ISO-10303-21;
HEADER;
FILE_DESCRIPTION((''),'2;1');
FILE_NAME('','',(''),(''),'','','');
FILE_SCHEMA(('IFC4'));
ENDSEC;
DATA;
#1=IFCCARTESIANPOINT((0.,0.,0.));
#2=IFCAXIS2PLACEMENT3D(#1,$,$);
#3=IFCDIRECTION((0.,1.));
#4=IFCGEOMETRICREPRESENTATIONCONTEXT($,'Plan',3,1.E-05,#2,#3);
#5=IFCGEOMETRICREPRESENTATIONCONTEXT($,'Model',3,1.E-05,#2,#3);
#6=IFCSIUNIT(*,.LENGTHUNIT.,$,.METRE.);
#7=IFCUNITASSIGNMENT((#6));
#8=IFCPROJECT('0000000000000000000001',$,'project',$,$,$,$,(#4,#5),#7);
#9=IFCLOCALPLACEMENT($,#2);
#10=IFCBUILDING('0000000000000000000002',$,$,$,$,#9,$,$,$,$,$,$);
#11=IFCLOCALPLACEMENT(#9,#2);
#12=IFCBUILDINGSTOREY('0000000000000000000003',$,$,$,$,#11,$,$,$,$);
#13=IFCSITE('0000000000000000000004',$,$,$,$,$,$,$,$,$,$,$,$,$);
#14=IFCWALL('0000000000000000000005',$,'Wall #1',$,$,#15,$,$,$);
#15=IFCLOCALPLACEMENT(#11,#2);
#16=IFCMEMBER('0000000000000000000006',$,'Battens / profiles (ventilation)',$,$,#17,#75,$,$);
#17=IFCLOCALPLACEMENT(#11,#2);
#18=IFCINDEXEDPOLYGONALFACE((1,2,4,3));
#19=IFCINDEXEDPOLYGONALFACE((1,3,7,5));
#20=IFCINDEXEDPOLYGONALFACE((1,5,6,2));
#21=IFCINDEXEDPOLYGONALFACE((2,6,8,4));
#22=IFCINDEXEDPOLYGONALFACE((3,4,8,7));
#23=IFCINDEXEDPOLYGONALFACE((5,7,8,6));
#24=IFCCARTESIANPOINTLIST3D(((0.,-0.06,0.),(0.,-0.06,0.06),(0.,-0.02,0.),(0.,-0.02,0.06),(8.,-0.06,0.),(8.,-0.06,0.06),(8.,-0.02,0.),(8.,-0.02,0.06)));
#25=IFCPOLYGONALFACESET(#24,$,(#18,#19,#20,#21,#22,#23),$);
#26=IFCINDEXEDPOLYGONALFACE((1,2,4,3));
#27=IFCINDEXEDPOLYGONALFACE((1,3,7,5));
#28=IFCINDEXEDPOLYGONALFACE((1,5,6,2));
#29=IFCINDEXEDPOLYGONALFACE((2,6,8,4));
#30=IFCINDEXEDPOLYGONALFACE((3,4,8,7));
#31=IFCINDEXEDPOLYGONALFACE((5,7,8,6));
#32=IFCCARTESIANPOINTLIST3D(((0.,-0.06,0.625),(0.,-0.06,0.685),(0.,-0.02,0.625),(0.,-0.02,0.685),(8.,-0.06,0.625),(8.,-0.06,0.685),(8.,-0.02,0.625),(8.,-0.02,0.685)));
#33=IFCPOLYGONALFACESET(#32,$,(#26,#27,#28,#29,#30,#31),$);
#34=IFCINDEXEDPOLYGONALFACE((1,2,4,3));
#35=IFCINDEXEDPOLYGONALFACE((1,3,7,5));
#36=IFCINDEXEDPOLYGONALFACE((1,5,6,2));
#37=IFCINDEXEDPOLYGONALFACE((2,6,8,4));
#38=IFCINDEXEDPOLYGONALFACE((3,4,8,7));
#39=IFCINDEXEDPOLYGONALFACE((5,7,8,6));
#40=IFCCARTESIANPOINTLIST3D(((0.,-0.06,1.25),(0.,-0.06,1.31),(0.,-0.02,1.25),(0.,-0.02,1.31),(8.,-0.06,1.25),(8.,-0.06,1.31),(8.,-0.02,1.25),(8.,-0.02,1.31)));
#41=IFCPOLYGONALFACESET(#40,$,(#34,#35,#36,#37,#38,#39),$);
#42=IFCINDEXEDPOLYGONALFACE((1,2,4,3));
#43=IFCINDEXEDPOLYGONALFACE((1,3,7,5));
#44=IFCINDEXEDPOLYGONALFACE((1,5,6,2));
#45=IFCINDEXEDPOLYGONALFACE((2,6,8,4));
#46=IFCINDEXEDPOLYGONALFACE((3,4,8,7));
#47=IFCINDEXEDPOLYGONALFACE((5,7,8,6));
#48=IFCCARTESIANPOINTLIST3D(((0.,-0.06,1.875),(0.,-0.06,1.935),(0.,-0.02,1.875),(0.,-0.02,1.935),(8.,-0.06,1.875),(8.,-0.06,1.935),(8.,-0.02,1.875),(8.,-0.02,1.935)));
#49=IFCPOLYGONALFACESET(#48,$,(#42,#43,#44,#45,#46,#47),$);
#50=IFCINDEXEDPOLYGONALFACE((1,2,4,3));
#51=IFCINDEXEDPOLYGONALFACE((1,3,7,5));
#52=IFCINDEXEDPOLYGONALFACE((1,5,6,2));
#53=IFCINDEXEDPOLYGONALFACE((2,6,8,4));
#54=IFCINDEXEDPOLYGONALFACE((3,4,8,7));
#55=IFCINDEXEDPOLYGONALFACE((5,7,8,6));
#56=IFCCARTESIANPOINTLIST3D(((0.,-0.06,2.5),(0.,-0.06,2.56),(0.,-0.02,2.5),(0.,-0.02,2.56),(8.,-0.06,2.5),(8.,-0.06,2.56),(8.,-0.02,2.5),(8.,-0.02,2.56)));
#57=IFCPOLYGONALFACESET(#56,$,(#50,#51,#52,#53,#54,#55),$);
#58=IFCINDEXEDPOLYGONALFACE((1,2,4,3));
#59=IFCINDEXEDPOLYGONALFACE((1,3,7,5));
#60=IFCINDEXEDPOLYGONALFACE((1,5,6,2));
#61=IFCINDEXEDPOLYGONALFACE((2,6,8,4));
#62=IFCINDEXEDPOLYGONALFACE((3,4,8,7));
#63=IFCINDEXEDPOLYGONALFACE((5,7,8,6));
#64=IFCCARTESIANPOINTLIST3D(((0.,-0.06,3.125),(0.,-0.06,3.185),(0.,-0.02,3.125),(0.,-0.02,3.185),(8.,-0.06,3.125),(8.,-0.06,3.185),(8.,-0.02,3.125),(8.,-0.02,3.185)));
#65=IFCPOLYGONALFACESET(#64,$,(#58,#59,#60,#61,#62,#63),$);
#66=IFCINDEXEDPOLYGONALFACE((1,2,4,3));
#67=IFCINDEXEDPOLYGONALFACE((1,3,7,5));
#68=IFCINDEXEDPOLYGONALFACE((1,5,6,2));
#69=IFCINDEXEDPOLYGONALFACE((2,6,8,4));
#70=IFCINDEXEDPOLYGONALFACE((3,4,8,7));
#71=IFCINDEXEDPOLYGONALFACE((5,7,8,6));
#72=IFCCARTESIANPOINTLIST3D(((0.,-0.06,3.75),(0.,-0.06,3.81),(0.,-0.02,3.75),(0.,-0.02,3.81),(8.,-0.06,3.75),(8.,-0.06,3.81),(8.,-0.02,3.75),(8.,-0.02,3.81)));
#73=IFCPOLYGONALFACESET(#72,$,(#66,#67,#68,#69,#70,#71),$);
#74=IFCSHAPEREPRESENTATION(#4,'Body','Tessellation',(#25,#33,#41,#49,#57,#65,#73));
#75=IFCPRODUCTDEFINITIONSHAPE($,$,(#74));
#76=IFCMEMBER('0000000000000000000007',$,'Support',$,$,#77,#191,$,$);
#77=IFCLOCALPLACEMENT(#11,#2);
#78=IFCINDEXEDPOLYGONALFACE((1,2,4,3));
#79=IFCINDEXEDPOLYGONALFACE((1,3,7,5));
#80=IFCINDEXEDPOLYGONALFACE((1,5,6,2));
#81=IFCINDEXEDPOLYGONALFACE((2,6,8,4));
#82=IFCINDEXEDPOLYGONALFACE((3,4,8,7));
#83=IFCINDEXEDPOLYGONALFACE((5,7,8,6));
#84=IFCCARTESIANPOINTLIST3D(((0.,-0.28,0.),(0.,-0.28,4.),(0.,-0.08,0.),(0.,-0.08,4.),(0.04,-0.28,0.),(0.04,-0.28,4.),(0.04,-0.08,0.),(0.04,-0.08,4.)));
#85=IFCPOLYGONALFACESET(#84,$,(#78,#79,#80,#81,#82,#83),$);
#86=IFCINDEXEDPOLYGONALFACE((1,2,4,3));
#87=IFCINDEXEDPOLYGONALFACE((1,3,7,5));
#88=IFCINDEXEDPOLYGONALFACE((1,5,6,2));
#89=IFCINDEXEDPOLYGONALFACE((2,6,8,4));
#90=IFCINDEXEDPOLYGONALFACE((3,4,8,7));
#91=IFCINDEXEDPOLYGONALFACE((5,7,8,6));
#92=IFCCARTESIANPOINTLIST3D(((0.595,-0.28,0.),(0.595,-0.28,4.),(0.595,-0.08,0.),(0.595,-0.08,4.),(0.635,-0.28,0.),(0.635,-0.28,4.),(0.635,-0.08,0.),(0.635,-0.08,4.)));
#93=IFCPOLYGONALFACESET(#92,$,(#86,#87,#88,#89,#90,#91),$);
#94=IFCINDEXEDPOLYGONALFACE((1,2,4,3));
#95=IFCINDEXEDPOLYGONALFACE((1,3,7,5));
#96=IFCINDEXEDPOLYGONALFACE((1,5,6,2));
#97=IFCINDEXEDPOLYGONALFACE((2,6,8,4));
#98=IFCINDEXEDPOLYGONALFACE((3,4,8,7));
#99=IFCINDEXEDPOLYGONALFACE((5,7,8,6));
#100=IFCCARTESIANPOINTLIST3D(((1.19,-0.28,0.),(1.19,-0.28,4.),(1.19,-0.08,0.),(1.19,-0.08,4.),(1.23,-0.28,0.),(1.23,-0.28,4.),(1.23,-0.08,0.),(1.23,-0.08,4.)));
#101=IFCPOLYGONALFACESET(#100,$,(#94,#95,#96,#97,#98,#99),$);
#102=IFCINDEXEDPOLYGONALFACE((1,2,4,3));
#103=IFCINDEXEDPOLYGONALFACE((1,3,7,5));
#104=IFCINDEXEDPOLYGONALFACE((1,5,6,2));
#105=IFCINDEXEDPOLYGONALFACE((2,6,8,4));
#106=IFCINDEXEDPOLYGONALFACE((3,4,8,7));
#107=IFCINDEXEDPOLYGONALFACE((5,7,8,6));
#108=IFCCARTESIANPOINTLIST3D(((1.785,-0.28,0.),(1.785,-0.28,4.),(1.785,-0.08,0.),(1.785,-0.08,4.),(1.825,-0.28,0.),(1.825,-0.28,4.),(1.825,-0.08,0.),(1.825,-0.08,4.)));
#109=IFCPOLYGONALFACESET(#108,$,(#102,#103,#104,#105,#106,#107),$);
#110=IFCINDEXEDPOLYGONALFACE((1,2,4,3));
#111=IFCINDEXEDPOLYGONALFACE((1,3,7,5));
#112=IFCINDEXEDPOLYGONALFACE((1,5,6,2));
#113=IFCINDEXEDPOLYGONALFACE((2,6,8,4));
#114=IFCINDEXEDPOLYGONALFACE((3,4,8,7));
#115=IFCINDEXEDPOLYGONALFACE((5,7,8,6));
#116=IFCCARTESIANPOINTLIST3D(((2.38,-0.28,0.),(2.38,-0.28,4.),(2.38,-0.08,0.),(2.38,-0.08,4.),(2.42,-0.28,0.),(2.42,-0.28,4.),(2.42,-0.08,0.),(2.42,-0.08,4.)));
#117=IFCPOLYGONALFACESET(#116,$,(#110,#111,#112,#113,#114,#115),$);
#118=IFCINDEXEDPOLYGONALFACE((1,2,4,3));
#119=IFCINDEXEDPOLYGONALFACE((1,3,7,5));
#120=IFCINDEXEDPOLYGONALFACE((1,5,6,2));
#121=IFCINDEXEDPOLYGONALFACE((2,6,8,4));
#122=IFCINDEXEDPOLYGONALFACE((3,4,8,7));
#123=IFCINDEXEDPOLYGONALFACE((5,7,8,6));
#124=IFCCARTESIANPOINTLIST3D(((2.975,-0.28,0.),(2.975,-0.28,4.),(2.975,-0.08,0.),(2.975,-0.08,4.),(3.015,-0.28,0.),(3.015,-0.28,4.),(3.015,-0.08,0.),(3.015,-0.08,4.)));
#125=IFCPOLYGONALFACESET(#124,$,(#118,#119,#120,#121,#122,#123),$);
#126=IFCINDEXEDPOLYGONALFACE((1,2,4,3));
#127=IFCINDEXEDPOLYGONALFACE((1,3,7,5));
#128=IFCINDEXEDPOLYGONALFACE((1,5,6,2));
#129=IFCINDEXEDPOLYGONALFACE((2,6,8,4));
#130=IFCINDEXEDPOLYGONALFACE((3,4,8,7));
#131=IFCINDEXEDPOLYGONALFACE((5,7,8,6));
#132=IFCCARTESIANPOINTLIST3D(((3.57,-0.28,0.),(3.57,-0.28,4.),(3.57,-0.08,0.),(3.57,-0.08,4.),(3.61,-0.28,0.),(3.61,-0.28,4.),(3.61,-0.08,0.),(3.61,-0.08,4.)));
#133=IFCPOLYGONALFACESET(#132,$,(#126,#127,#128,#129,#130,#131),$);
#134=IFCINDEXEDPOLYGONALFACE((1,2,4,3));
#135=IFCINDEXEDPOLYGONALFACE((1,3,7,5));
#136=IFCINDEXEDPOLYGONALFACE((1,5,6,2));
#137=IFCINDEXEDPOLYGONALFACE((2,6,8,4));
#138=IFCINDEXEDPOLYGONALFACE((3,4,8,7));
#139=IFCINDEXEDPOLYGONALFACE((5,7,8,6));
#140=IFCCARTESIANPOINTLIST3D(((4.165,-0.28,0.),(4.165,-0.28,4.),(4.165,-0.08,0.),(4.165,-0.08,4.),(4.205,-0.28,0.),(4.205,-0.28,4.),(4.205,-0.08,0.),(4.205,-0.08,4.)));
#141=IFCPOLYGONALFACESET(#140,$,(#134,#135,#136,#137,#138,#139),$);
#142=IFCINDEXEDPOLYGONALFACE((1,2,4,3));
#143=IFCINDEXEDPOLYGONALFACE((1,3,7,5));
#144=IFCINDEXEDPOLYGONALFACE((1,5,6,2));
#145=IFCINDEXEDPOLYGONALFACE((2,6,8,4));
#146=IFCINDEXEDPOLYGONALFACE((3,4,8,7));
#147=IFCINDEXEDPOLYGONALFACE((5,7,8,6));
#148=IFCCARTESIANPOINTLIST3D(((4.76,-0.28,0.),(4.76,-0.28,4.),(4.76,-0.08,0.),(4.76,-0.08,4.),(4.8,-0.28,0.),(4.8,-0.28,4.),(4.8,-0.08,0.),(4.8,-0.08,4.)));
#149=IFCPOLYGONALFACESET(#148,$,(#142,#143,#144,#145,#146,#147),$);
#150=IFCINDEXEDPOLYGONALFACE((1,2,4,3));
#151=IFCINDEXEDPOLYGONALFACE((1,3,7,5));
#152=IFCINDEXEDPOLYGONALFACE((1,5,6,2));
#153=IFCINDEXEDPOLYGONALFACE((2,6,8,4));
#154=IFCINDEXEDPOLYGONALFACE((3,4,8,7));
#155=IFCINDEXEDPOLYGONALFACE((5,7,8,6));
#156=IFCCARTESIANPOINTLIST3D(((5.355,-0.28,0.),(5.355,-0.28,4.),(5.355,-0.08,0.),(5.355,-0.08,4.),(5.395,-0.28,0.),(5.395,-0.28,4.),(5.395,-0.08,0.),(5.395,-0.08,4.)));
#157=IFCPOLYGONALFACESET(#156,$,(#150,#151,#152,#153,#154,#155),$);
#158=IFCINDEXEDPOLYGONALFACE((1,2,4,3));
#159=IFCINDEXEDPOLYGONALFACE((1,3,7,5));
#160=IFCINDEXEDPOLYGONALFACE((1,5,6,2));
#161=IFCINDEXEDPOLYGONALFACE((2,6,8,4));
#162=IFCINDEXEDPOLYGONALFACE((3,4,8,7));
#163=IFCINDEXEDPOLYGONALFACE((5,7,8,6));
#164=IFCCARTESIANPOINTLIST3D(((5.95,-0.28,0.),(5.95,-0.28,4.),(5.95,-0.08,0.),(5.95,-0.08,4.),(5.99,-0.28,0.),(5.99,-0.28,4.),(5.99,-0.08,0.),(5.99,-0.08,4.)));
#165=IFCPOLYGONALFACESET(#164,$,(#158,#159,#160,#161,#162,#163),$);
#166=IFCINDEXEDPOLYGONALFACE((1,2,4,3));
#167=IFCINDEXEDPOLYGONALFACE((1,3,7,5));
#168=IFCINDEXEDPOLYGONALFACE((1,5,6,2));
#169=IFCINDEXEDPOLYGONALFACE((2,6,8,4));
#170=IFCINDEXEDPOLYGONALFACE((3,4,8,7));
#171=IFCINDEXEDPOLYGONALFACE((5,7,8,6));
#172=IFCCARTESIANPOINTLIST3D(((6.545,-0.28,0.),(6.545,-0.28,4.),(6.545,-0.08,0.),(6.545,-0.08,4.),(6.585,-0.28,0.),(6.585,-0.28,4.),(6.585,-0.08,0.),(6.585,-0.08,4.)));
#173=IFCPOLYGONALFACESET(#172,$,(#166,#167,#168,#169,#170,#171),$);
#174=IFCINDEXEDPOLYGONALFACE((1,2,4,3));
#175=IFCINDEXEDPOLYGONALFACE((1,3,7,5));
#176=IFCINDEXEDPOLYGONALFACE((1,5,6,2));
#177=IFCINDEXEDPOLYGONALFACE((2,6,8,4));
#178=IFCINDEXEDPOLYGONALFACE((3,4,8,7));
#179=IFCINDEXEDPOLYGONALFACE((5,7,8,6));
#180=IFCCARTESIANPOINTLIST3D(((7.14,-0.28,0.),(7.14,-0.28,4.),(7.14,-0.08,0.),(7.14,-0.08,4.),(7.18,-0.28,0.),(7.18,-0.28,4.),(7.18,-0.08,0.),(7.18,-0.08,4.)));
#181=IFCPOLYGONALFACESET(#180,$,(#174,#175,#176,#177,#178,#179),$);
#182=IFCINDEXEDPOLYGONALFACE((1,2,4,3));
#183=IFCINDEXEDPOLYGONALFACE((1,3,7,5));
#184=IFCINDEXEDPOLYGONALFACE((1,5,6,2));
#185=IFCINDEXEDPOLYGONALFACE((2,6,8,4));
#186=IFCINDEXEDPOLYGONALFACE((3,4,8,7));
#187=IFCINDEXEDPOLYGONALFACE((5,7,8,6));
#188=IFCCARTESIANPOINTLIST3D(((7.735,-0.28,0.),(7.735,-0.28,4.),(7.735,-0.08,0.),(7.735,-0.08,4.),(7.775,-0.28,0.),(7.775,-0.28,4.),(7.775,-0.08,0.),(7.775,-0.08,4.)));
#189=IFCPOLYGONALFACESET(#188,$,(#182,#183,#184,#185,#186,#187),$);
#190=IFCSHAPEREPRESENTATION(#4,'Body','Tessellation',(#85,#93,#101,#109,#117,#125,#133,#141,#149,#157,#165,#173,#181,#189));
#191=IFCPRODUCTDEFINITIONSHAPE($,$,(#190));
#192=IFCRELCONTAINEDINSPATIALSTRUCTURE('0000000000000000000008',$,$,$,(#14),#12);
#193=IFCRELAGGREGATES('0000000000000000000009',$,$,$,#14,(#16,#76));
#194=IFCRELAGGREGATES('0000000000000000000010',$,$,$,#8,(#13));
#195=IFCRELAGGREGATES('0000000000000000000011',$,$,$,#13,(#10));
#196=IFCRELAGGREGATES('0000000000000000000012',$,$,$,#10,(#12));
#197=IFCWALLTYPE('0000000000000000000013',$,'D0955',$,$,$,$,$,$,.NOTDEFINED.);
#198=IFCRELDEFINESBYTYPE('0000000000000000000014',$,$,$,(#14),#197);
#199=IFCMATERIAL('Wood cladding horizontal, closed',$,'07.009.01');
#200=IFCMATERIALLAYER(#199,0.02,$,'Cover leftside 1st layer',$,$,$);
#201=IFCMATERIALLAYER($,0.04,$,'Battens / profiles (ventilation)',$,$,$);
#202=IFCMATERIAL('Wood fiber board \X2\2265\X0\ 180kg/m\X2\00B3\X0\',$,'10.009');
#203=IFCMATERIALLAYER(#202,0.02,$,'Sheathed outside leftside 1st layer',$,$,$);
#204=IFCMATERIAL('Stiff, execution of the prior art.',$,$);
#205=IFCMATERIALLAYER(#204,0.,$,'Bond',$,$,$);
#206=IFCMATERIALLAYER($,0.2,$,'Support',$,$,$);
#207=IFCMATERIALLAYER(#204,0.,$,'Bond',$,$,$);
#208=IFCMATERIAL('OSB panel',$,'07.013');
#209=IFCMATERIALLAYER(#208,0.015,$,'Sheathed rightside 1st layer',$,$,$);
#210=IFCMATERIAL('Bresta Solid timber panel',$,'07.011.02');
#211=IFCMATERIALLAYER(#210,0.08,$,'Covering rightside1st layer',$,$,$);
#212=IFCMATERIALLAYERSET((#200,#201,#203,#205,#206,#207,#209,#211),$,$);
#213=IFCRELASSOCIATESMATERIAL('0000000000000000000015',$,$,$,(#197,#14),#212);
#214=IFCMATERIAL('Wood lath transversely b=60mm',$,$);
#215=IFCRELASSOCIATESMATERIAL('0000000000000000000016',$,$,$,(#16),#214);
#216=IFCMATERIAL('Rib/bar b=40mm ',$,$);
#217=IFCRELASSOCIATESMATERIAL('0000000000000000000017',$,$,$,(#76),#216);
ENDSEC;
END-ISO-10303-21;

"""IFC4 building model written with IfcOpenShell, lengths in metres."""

from ifc_helpers import new_model, si_unit, direction, frame, frame_2d, origin, place, context, project, spatial, rectangle, extrude, material, layer, layer_set, type_object, element, aggregate, save


model = new_model("IFC4")

# Units and contexts
plan_context = context("Plan", 3, precision=1e-05, world=origin(), true_north=direction((0.0, 1.0)))
model_context = context("Model", 3, precision=1e-05, world=origin(), true_north=direction((0.0, 1.0)))
ifc_project = project(units=[si_unit("LENGTHUNIT", "METRE")], contexts=[plan_context, model_context])

# Site, building, storey
site = spatial("IfcSite", under=ifc_project)
building_placement = place(None, origin())
building = spatial("IfcBuilding", under=site, at=building_placement)
storey_placement = place(building_placement, origin())
storey = spatial("IfcBuildingStorey", under=building, at=storey_placement)

# Wall, members
ifc_material_1 = material(Name="Wood cladding horizontal, closed", Category="07.009.01")
ifc_layer_1 = layer(ifc_material_1, 0.02, Name="Cover leftside 1st layer")
ifc_layer_2 = layer(None, 0.04, Name="Battens / profiles (ventilation)")
ifc_material_2 = material(Name="Wood fiber board ≥ 180kg/m³", Category="10.009")
ifc_layer_3 = layer(ifc_material_2, 0.02, Name="Sheathed outside leftside 1st layer")
ifc_material_3 = material(Name="Stiff, execution of the prior art.")
ifc_layer_4 = layer(ifc_material_3, 0.0, Name="Bond")
ifc_layer_5 = layer(None, 0.2, Name="Support")
ifc_layer_6 = layer(ifc_material_3, 0.0, Name="Bond")
ifc_material_4 = material(Name="OSB panel", Category="07.013")
ifc_layer_7 = layer(ifc_material_4, 0.015, Name="Sheathed rightside 1st layer")
ifc_material_5 = material(Name="Bresta Solid timber panel", Category="07.011.02")
ifc_layer_8 = layer(ifc_material_5, 0.08, Name="Covering rightside1st layer")
ifc_layer_set = layer_set([ifc_layer_1, ifc_layer_2, ifc_layer_3, ifc_layer_4, ifc_layer_5, ifc_layer_6, ifc_layer_7, ifc_layer_8])
wall_type = type_object("IfcWallType", Name="D0955", PredefinedType="NOTDEFINED", material=ifc_layer_set)
wall_placement = place(None, frame((0.0, 0.0, 0.0), z_axis=(0.0, -1.0, 0.0), x_axis=(1.0, 0.0, 0.0)))
wall = element("IfcWall", 1, at=wall_placement, inside=storey, type_object=wall_type, material=ifc_layer_set, Name="Wall #1")
ifc_material_6 = material(Name="Wood lath transversely b=60mm")
member_1_placement = place(wall_placement, origin())
member_1 = element("IfcMember", 2, at=member_1_placement, material=ifc_material_6, Name="Battens / profiles (ventilation)", context=plan_context, shape_type="SweptSolid", body=[
    extrude(rectangle(XDim=0.06, YDim=0.04, at=frame_2d((0.03, 0.02), x_axis=(1.0, 0.0))), frame((0.0, 0.0, 0.02), z_axis=(1.0, 0.0, 0.0), x_axis=(0.0, 1.0, 0.0)), (0.0, 0.0, 1.0), 8.0),
    extrude(rectangle(XDim=0.06, YDim=0.04, at=frame_2d((0.03, 0.02), x_axis=(1.0, 0.0))), frame((0.0, 0.625, 0.02), z_axis=(1.0, 0.0, 0.0), x_axis=(0.0, 1.0, 0.0)), (0.0, 0.0, 1.0), 8.0),
    extrude(rectangle(XDim=0.06, YDim=0.04, at=frame_2d((0.03, 0.02), x_axis=(1.0, 0.0))), frame((0.0, 1.25, 0.02), z_axis=(1.0, 0.0, 0.0), x_axis=(0.0, 1.0, 0.0)), (0.0, 0.0, 1.0), 8.0),
    extrude(rectangle(XDim=0.06, YDim=0.04, at=frame_2d((0.03, 0.02), x_axis=(1.0, 0.0))), frame((0.0, 1.875, 0.02), z_axis=(1.0, 0.0, 0.0), x_axis=(0.0, 1.0, 0.0)), (0.0, 0.0, 1.0), 8.0),
    extrude(rectangle(XDim=0.06, YDim=0.04, at=frame_2d((0.03, 0.02), x_axis=(1.0, 0.0))), frame((0.0, 2.5, 0.02), z_axis=(1.0, 0.0, 0.0), x_axis=(0.0, 1.0, 0.0)), (0.0, 0.0, 1.0), 8.0),
    extrude(rectangle(XDim=0.06, YDim=0.04, at=frame_2d((0.03, 0.02), x_axis=(1.0, 0.0))), frame((0.0, 3.125, 0.02), z_axis=(1.0, 0.0, 0.0), x_axis=(0.0, 1.0, 0.0)), (0.0, 0.0, 1.0), 8.0),
    extrude(rectangle(XDim=0.06, YDim=0.04, at=frame_2d((0.03, 0.02), x_axis=(1.0, 0.0))), frame((0.0, 3.75, 0.02), z_axis=(1.0, 0.0, 0.0), x_axis=(0.0, 1.0, 0.0)), (0.0, 0.0, 1.0), 8.0),
])
ifc_material_7 = material(Name="Rib/bar b=40mm ")
member_2_placement = place(wall_placement, origin())
member_2 = element("IfcMember", 3, at=member_2_placement, material=ifc_material_7, Name="Support", context=plan_context, shape_type="SweptSolid", body=[
    extrude(rectangle(XDim=0.04, YDim=0.2, at=frame_2d((0.02, 0.1), x_axis=(1.0, 0.0))), frame((0.0, 4.0, 0.08), z_axis=(0.0, -1.0, 0.0), x_axis=(1.0, 0.0, 0.0)), (0.0, 0.0, 1.0), 4.0),
    extrude(rectangle(XDim=0.04, YDim=0.2, at=frame_2d((0.02, 0.1), x_axis=(1.0, 0.0))), frame((0.595, 4.0, 0.08), z_axis=(0.0, -1.0, 0.0), x_axis=(1.0, 0.0, 0.0)), (0.0, 0.0, 1.0), 4.0),
    extrude(rectangle(XDim=0.04, YDim=0.2, at=frame_2d((0.02, 0.1), x_axis=(1.0, 0.0))), frame((1.19, 4.0, 0.08), z_axis=(0.0, -1.0, 0.0), x_axis=(1.0, 0.0, 0.0)), (0.0, 0.0, 1.0), 4.0),
    extrude(rectangle(XDim=0.04, YDim=0.2, at=frame_2d((0.02, 0.1), x_axis=(1.0, 0.0))), frame((1.785, 4.0, 0.08), z_axis=(0.0, -1.0, 0.0), x_axis=(1.0, 0.0, 0.0)), (0.0, 0.0, 1.0), 4.0),
    extrude(rectangle(XDim=0.04, YDim=0.2, at=frame_2d((0.02, 0.1), x_axis=(1.0, 0.0))), frame((2.38, 4.0, 0.08), z_axis=(0.0, -1.0, 0.0), x_axis=(1.0, 0.0, 0.0)), (0.0, 0.0, 1.0), 4.0),
    extrude(rectangle(XDim=0.04, YDim=0.2, at=frame_2d((0.02, 0.1), x_axis=(1.0, 0.0))), frame((2.975, 4.0, 0.08), z_axis=(0.0, -1.0, 0.0), x_axis=(1.0, 0.0, 0.0)), (0.0, 0.0, 1.0), 4.0),
    extrude(rectangle(XDim=0.04, YDim=0.2, at=frame_2d((0.02, 0.1), x_axis=(1.0, 0.0))), frame((3.57, 4.0, 0.08), z_axis=(0.0, -1.0, 0.0), x_axis=(1.0, 0.0, 0.0)), (0.0, 0.0, 1.0), 4.0),
    extrude(rectangle(XDim=0.04, YDim=0.2, at=frame_2d((0.02, 0.1), x_axis=(1.0, 0.0))), frame((4.165, 4.0, 0.08), z_axis=(0.0, -1.0, 0.0), x_axis=(1.0, 0.0, 0.0)), (0.0, 0.0, 1.0), 4.0),
    extrude(rectangle(XDim=0.04, YDim=0.2, at=frame_2d((0.02, 0.1), x_axis=(1.0, 0.0))), frame((4.76, 4.0, 0.08), z_axis=(0.0, -1.0, 0.0), x_axis=(1.0, 0.0, 0.0)), (0.0, 0.0, 1.0), 4.0),
    extrude(rectangle(XDim=0.04, YDim=0.2, at=frame_2d((0.02, 0.1), x_axis=(1.0, 0.0))), frame((5.355, 4.0, 0.08), z_axis=(0.0, -1.0, 0.0), x_axis=(1.0, 0.0, 0.0)), (0.0, 0.0, 1.0), 4.0),
    extrude(rectangle(XDim=0.04, YDim=0.2, at=frame_2d((0.02, 0.1), x_axis=(1.0, 0.0))), frame((5.95, 4.0, 0.08), z_axis=(0.0, -1.0, 0.0), x_axis=(1.0, 0.0, 0.0)), (0.0, 0.0, 1.0), 4.0),
    extrude(rectangle(XDim=0.04, YDim=0.2, at=frame_2d((0.02, 0.1), x_axis=(1.0, 0.0))), frame((6.545, 4.0, 0.08), z_axis=(0.0, -1.0, 0.0), x_axis=(1.0, 0.0, 0.0)), (0.0, 0.0, 1.0), 4.0),
    extrude(rectangle(XDim=0.04, YDim=0.2, at=frame_2d((0.02, 0.1), x_axis=(1.0, 0.0))), frame((7.14, 4.0, 0.08), z_axis=(0.0, -1.0, 0.0), x_axis=(1.0, 0.0, 0.0)), (0.0, 0.0, 1.0), 4.0),
    extrude(rectangle(XDim=0.04, YDim=0.2, at=frame_2d((0.02, 0.1), x_axis=(1.0, 0.0))), frame((7.735, 4.0, 0.08), z_axis=(0.0, -1.0, 0.0), x_axis=(1.0, 0.0, 0.0)), (0.0, 0.0, 1.0), 4.0),
])
aggregate(wall, [member_1, member_2])

save(model, "model.ifc")
